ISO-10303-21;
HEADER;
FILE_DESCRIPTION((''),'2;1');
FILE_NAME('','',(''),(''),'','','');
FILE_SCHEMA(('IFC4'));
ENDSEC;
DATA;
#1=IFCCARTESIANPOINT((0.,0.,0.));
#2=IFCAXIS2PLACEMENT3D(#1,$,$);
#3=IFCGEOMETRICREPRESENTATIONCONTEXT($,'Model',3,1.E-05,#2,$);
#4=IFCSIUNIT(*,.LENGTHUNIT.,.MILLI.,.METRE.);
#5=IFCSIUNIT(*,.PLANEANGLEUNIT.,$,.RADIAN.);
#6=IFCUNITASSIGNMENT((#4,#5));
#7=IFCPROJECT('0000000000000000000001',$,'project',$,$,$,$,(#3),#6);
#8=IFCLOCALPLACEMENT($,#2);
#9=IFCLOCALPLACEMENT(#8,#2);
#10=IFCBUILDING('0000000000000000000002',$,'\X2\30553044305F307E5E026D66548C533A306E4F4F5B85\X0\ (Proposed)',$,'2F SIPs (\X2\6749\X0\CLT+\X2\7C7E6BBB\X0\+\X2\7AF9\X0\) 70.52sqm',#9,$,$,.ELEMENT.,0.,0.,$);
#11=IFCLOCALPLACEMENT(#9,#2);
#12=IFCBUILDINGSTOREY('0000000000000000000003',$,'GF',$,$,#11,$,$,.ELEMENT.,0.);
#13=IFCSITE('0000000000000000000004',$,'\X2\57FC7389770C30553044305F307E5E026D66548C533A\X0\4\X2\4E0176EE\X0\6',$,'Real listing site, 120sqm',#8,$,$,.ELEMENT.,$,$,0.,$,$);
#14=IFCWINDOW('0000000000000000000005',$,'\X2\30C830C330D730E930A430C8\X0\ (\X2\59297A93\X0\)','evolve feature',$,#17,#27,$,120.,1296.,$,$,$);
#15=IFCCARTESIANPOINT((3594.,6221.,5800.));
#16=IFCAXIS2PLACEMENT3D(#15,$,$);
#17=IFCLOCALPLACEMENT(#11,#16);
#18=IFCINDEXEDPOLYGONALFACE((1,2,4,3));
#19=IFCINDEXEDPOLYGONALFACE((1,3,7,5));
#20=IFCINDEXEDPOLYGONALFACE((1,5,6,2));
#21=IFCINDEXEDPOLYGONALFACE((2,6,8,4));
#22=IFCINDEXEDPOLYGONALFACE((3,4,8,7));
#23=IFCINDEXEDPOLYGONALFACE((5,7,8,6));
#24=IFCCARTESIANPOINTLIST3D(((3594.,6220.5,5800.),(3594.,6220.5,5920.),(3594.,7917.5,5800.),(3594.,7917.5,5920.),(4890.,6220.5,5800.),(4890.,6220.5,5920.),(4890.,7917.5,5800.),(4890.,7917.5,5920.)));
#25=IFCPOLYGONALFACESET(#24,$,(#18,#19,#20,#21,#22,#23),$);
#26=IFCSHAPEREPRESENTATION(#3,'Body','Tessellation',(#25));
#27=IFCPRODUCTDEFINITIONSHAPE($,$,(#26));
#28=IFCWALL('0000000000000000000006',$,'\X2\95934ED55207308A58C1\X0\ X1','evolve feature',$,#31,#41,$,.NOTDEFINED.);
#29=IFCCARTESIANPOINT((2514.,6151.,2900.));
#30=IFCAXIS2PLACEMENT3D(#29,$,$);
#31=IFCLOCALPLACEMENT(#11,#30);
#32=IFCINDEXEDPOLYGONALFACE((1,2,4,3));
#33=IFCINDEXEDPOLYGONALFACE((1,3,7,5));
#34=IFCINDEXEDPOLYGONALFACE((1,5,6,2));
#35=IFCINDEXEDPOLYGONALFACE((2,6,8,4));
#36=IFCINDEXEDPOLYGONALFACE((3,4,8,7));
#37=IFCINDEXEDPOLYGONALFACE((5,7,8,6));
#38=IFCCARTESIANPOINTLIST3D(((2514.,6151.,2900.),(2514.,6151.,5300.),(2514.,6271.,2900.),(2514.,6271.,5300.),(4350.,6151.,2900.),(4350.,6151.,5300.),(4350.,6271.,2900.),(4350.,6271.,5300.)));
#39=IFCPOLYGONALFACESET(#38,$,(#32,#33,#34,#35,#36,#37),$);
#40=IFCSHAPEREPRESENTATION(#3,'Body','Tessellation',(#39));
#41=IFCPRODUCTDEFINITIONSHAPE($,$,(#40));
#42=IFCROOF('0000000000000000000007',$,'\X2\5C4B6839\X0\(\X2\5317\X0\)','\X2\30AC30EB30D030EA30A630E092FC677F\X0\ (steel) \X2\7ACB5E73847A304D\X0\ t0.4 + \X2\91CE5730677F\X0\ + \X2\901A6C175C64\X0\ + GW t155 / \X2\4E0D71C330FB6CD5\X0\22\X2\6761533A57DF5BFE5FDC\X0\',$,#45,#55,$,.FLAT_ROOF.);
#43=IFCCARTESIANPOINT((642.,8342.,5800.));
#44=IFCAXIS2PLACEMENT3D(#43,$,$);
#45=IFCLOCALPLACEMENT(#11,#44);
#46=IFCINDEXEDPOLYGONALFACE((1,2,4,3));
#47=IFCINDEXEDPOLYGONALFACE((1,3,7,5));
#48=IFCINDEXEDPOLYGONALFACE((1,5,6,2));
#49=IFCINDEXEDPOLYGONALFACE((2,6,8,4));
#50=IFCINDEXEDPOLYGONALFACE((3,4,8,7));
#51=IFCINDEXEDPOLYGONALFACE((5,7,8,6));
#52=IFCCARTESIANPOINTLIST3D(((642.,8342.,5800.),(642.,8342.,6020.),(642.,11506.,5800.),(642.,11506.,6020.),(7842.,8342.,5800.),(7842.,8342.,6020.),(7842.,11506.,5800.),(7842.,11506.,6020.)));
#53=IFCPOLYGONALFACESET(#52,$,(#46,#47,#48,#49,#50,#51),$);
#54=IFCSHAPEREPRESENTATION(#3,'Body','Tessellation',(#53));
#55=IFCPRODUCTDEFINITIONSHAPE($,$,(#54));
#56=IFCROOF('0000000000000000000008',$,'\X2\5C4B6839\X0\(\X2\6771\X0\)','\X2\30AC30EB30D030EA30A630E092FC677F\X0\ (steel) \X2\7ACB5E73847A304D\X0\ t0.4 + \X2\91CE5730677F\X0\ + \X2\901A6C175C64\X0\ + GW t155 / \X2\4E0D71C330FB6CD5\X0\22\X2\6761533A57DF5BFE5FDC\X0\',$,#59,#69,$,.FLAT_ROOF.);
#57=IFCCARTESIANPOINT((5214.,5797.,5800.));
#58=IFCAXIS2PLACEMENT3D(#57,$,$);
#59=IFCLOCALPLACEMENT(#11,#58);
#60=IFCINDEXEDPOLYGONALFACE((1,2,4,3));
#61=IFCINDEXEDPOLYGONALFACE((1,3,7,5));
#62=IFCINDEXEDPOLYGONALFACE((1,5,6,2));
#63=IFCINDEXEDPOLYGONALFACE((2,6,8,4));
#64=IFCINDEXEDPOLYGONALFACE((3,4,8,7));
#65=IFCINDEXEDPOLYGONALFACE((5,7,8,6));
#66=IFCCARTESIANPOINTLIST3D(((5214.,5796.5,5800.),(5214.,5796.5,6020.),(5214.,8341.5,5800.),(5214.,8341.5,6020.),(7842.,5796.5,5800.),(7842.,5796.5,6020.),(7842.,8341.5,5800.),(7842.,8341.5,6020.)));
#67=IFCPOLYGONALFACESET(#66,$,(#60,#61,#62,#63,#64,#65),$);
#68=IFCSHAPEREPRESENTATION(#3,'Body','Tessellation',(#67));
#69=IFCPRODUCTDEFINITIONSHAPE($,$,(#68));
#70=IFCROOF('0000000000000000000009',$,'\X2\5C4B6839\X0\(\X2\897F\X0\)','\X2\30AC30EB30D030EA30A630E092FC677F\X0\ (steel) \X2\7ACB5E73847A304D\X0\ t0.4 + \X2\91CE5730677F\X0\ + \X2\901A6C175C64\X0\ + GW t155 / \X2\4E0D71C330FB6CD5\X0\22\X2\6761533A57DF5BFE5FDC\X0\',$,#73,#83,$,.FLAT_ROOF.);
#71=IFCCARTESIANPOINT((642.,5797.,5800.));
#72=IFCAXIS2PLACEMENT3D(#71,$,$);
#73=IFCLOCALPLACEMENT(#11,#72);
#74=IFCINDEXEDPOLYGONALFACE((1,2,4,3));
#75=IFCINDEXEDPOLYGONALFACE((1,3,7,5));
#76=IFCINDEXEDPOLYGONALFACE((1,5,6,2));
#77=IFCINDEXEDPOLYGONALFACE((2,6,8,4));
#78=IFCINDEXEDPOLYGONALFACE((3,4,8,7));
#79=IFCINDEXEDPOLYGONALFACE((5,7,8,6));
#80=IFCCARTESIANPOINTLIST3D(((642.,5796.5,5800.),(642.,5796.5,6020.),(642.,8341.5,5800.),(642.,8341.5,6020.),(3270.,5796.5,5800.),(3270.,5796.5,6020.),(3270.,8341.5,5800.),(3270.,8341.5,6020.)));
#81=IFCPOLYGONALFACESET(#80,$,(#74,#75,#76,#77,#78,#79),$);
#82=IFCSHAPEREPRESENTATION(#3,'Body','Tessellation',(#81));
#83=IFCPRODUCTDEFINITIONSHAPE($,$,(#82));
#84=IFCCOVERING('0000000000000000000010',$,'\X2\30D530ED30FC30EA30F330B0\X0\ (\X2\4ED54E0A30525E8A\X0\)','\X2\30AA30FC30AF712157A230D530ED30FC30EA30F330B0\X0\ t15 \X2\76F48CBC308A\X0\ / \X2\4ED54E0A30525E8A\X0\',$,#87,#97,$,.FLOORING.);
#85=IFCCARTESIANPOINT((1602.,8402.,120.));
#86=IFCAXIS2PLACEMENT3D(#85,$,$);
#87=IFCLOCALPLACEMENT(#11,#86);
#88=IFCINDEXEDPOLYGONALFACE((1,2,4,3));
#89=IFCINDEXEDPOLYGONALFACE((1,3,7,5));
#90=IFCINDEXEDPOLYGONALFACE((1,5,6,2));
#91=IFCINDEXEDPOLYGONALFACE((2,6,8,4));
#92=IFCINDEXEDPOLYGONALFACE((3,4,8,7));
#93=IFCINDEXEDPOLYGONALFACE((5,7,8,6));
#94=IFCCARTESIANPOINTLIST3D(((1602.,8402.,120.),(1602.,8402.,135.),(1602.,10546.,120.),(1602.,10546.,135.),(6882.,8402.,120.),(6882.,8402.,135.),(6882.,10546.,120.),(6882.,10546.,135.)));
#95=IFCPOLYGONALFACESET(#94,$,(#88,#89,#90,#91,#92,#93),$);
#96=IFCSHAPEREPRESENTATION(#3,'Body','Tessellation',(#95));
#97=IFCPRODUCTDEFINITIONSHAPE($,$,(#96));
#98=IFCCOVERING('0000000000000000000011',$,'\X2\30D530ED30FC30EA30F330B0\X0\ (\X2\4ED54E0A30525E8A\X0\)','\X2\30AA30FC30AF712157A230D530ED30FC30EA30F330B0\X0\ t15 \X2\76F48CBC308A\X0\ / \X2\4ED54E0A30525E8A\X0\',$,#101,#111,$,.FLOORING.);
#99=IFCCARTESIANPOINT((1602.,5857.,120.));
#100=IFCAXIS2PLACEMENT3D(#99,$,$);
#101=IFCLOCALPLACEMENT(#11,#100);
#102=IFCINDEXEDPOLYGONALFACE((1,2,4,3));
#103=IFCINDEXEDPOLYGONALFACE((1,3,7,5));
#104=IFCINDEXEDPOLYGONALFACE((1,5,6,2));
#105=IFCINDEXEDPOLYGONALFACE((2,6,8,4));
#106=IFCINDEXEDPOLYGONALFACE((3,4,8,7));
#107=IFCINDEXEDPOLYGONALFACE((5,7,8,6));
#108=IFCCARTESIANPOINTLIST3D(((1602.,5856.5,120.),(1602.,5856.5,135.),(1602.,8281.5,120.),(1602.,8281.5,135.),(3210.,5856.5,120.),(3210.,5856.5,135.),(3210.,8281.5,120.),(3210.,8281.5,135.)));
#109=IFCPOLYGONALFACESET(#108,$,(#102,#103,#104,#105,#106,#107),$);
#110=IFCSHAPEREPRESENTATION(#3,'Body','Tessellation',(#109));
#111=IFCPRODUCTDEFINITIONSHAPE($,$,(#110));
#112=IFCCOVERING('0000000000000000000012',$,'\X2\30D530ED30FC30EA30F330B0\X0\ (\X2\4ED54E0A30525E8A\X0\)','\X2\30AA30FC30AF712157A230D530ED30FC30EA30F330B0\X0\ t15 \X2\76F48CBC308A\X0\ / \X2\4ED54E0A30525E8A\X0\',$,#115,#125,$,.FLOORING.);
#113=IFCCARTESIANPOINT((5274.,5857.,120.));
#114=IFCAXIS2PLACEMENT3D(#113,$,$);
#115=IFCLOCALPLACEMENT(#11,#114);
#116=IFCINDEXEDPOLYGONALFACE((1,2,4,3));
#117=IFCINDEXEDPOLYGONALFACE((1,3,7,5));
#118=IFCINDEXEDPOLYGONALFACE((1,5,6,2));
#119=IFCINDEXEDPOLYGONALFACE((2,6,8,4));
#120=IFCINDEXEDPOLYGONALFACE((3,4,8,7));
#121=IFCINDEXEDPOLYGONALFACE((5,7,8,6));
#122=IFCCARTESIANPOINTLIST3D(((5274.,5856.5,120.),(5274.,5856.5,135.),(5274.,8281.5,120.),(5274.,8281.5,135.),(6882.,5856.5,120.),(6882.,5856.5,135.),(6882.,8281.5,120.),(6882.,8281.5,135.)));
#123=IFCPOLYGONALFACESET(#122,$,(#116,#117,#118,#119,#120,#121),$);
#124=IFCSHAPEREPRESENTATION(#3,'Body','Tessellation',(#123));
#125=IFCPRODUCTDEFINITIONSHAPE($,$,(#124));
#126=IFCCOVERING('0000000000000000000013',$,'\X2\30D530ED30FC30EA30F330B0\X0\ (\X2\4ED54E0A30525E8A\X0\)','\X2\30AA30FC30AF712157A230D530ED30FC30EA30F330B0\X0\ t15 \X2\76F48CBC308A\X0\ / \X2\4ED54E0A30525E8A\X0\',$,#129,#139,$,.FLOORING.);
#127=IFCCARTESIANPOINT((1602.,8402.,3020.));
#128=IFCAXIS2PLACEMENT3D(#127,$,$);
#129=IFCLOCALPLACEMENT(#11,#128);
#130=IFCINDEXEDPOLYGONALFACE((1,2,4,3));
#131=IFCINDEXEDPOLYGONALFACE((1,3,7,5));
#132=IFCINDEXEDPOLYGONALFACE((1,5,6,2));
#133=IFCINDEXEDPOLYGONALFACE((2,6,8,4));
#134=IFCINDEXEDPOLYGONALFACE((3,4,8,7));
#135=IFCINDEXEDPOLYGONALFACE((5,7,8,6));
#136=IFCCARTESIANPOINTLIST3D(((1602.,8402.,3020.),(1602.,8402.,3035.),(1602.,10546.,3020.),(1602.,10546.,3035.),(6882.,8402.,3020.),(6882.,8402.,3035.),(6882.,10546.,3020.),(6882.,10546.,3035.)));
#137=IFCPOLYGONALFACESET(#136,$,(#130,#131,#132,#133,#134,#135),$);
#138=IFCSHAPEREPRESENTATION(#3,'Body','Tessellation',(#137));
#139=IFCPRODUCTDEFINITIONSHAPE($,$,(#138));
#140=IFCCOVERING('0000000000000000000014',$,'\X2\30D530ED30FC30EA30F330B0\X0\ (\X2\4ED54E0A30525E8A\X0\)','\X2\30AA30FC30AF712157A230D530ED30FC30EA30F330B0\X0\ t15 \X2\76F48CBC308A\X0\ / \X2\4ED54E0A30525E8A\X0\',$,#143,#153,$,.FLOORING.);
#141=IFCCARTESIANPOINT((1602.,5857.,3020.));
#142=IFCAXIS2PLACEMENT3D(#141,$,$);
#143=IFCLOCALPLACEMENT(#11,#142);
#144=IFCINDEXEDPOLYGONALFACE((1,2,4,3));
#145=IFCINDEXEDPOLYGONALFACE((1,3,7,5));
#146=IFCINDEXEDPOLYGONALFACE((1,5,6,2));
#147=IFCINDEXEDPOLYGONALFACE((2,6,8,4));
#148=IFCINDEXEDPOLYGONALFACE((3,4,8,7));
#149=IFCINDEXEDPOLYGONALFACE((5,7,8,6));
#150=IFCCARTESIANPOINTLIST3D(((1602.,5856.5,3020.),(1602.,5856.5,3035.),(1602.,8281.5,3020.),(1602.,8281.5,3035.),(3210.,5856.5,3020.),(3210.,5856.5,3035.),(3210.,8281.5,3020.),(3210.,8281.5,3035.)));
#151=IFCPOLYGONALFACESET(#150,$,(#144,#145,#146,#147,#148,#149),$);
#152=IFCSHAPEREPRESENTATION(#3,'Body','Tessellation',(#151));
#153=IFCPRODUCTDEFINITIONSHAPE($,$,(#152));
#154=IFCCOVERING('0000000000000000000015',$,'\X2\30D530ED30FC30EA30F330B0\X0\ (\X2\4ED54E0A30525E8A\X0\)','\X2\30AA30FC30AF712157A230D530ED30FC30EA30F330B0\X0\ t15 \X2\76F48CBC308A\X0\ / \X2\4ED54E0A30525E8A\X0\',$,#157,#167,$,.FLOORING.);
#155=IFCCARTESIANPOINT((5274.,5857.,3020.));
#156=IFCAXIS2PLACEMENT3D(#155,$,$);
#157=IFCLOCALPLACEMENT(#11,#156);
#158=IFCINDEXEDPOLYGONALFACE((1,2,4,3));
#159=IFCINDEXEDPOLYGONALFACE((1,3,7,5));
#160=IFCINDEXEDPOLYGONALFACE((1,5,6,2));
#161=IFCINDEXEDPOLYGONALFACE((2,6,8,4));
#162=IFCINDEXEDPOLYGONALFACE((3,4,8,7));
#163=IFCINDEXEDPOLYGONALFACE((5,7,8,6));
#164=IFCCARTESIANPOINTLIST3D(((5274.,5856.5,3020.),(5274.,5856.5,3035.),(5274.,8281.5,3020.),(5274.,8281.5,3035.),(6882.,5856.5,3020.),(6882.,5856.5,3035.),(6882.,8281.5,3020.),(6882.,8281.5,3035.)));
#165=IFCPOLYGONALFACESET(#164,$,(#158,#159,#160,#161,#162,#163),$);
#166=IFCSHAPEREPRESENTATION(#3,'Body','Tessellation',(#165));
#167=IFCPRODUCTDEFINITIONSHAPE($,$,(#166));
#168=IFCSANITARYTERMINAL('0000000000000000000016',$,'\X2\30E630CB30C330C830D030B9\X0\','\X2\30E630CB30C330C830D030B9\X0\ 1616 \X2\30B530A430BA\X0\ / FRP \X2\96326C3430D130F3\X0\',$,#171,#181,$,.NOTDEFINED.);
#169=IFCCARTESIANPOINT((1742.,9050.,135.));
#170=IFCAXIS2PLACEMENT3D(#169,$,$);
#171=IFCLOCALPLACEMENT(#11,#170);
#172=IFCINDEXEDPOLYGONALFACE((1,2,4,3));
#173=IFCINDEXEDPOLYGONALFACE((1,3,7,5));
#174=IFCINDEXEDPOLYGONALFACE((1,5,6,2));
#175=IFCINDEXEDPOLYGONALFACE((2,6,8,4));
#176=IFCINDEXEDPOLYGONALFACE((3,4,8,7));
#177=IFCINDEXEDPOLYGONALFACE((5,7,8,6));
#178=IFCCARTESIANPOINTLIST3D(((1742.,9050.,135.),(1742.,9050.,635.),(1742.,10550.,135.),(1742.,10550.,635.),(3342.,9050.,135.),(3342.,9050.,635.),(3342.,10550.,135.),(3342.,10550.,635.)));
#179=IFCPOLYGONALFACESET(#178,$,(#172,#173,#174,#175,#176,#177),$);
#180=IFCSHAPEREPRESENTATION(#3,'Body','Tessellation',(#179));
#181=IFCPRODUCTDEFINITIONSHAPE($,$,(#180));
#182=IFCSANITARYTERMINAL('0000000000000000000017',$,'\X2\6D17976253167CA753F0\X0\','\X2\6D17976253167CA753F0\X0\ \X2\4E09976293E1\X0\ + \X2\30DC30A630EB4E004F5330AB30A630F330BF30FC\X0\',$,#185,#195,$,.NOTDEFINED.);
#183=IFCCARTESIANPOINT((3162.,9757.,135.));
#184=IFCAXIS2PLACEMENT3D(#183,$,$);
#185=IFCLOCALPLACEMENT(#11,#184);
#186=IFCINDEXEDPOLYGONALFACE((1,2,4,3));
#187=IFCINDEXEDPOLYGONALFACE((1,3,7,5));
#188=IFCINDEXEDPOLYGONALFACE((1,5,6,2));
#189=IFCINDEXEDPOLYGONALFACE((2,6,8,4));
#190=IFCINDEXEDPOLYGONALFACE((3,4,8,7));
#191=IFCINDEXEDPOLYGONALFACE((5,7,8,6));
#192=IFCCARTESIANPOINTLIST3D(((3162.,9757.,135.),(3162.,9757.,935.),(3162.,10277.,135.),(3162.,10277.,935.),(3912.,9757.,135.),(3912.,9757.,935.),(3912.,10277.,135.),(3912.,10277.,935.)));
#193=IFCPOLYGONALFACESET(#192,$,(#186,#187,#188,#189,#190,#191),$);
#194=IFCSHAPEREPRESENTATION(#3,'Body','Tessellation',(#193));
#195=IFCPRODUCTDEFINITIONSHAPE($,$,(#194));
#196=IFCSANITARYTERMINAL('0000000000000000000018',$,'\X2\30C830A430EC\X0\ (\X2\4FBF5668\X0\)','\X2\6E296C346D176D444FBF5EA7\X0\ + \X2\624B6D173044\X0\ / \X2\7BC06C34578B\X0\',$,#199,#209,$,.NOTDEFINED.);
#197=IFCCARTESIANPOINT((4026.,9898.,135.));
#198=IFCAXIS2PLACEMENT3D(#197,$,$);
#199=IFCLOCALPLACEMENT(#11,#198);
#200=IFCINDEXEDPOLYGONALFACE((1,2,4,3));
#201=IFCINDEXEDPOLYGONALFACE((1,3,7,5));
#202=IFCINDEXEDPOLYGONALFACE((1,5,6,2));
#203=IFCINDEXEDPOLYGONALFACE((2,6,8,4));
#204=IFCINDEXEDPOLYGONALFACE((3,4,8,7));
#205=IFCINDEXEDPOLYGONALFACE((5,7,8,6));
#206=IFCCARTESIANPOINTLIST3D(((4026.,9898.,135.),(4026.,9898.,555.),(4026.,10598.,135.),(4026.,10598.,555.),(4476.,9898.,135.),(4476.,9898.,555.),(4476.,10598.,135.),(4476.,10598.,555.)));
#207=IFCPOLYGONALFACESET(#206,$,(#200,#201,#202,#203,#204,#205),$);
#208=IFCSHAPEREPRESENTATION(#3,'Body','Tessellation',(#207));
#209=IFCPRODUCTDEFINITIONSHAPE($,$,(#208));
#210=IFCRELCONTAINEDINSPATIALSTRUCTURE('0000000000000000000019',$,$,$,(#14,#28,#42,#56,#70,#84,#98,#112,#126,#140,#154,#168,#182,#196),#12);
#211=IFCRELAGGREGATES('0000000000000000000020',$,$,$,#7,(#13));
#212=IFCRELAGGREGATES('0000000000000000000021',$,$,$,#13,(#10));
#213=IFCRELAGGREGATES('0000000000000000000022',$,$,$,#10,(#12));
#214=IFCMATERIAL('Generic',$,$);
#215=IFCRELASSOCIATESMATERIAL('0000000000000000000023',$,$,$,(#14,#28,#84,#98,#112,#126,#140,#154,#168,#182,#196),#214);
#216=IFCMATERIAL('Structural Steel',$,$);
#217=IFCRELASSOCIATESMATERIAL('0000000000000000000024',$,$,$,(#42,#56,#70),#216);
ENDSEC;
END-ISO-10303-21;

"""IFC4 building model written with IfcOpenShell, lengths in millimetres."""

from ifc_helpers import new_model, si_unit, frame, frame_2d, origin, place, context, project, spatial, rectangle, extrude, material, element, save


model = new_model("IFC4")

# Units and contexts
model_context = context("Model", 3, precision=1e-05, world=origin())
ifc_project = project(units=[si_unit("LENGTHUNIT", "METRE", prefix="MILLI"), si_unit("PLANEANGLEUNIT", "RADIAN")], contexts=[model_context])

# Site, building, storey
site_placement = place(None, origin())
site = spatial("IfcSite", under=ifc_project, at=site_placement, Name="埼玉県さいたま市浦和区4丁目6", ObjectType="Real listing site, 120sqm", CompositionType="ELEMENT", RefElevation=0.0)
building_placement = place(site_placement, origin())
building = spatial("IfcBuilding", under=site, at=building_placement, Name="さいたま市浦和区の住宅 (Proposed)", ObjectType="2F SIPs (杉CLT+籾殻+竹) 70.52sqm", CompositionType="ELEMENT", ElevationOfRefHeight=0.0, ElevationOfTerrain=0.0)
storey_placement = place(building_placement, origin())
storey = spatial("IfcBuildingStorey", under=building, at=storey_placement, Name="GF", CompositionType="ELEMENT", Elevation=0.0)

# Window
ifc_material_1 = material(Name="Generic")
window_1_placement = place(storey_placement, frame((3594.0, 6221.0, 5800.0)))
element("IfcWindow", 1, at=window_1_placement, inside=storey, material=ifc_material_1, Name="トップライト (天窓)", Description="evolve feature", OverallHeight=120.0, OverallWidth=1296.0, context=model_context, shape_type="SweptSolid", body=[
    extrude(rectangle(XDim=1296.0, YDim=1697.0, at=frame_2d((648.0, 848.0))), frame((3594.0, 6221.0, 5800.0)), (0.0, 0.0, 1.0), 120.0),
])

# Wall
wall_1_placement = place(storey_placement, frame((2514.0, 6151.0, 2900.0)))
element("IfcWall", 2, at=wall_1_placement, inside=storey, material=ifc_material_1, Name="間仕切り壁 X1", Description="evolve feature", PredefinedType="NOTDEFINED", context=model_context, shape_type="SweptSolid", body=[
    extrude(rectangle(XDim=1836.0, YDim=120.0, at=frame_2d((918.0, 60.0))), frame((2514.0, 6151.0, 2900.0)), (0.0, 0.0, 1.0), 2400.0),
])

# Roofs
ifc_material_2 = material(Name="Structural Steel")
roof_1_placement = place(storey_placement, frame((642.0, 8342.0, 5800.0)))
element("IfcRoof", 3, at=roof_1_placement, inside=storey, material=ifc_material_2, Name="屋根(北)", Description="ガルバリウム鋼板 (steel) 立平葺き t0.4 + 野地板 + 通気層 + GW t155 / 不燃・法22条区域対応", PredefinedType="FLAT_ROOF", context=model_context, shape_type="SweptSolid", body=[
    extrude(rectangle(XDim=7200.0, YDim=3164.0, at=frame_2d((3600.0, 1582.0))), frame((642.0, 8342.0, 5800.0)), (0.0, 0.0, 1.0), 220.0),
])
roof_2_placement = place(storey_placement, frame((5214.0, 5797.0, 5800.0)))
element("IfcRoof", 4, at=roof_2_placement, inside=storey, material=ifc_material_2, Name="屋根(東)", Description="ガルバリウム鋼板 (steel) 立平葺き t0.4 + 野地板 + 通気層 + GW t155 / 不燃・法22条区域対応", PredefinedType="FLAT_ROOF", context=model_context, shape_type="SweptSolid", body=[
    extrude(rectangle(XDim=2628.0, YDim=2545.0, at=frame_2d((1314.0, 1272.0))), frame((5214.0, 5797.0, 5800.0)), (0.0, 0.0, 1.0), 220.0),
])
roof_3_placement = place(storey_placement, frame((642.0, 5797.0, 5800.0)))
element("IfcRoof", 5, at=roof_3_placement, inside=storey, material=ifc_material_2, Name="屋根(西)", Description="ガルバリウム鋼板 (steel) 立平葺き t0.4 + 野地板 + 通気層 + GW t155 / 不燃・法22条区域対応", PredefinedType="FLAT_ROOF", context=model_context, shape_type="SweptSolid", body=[
    extrude(rectangle(XDim=2628.0, YDim=2545.0, at=frame_2d((1314.0, 1272.0))), frame((642.0, 5797.0, 5800.0)), (0.0, 0.0, 1.0), 220.0),
])

# Coverings
covering_1_placement = place(storey_placement, frame((1602.0, 8402.0, 120.0)))
element("IfcCovering", 6, at=covering_1_placement, inside=storey, material=ifc_material_1, Name="フローリング (仕上げ床)", Description="オーク無垢フローリング t15 直貼り / 仕上げ床", PredefinedType="FLOORING", context=model_context, shape_type="SweptSolid", body=[
    extrude(rectangle(XDim=5280.0, YDim=2144.0, at=frame_2d((2640.0, 1072.0))), frame((1602.0, 8402.0, 120.0)), (0.0, 0.0, 1.0), 15.0),
])
covering_2_placement = place(storey_placement, frame((1602.0, 5857.0, 120.0)))
element("IfcCovering", 7, at=covering_2_placement, inside=storey, material=ifc_material_1, Name="フローリング (仕上げ床)", Description="オーク無垢フローリング t15 直貼り / 仕上げ床", PredefinedType="FLOORING", context=model_context, shape_type="SweptSolid", body=[
    extrude(rectangle(XDim=1608.0, YDim=2425.0, at=frame_2d((804.0, 1212.0))), frame((1602.0, 5857.0, 120.0)), (0.0, 0.0, 1.0), 15.0),
])
covering_3_placement = place(storey_placement, frame((5274.0, 5857.0, 120.0)))
element("IfcCovering", 8, at=covering_3_placement, inside=storey, material=ifc_material_1, Name="フローリング (仕上げ床)", Description="オーク無垢フローリング t15 直貼り / 仕上げ床", PredefinedType="FLOORING", context=model_context, shape_type="SweptSolid", body=[
    extrude(rectangle(XDim=1608.0, YDim=2425.0, at=frame_2d((804.0, 1212.0))), frame((5274.0, 5857.0, 120.0)), (0.0, 0.0, 1.0), 15.0),
])
covering_4_placement = place(storey_placement, frame((1602.0, 8402.0, 3020.0)))
element("IfcCovering", 9, at=covering_4_placement, inside=storey, material=ifc_material_1, Name="フローリング (仕上げ床)", Description="オーク無垢フローリング t15 直貼り / 仕上げ床", PredefinedType="FLOORING", context=model_context, shape_type="SweptSolid", body=[
    extrude(rectangle(XDim=5280.0, YDim=2144.0, at=frame_2d((2640.0, 1072.0))), frame((1602.0, 8402.0, 3020.0)), (0.0, 0.0, 1.0), 15.0),
])
covering_5_placement = place(storey_placement, frame((1602.0, 5857.0, 3020.0)))
element("IfcCovering", 10, at=covering_5_placement, inside=storey, material=ifc_material_1, Name="フローリング (仕上げ床)", Description="オーク無垢フローリング t15 直貼り / 仕上げ床", PredefinedType="FLOORING", context=model_context, shape_type="SweptSolid", body=[
    extrude(rectangle(XDim=1608.0, YDim=2425.0, at=frame_2d((804.0, 1212.0))), frame((1602.0, 5857.0, 3020.0)), (0.0, 0.0, 1.0), 15.0),
])
covering_6_placement = place(storey_placement, frame((5274.0, 5857.0, 3020.0)))
element("IfcCovering", 11, at=covering_6_placement, inside=storey, material=ifc_material_1, Name="フローリング (仕上げ床)", Description="オーク無垢フローリング t15 直貼り / 仕上げ床", PredefinedType="FLOORING", context=model_context, shape_type="SweptSolid", body=[
    extrude(rectangle(XDim=1608.0, YDim=2425.0, at=frame_2d((804.0, 1212.0))), frame((5274.0, 5857.0, 3020.0)), (0.0, 0.0, 1.0), 15.0),
])

# Sanitary terminals
sanitary_terminal_1_placement = place(storey_placement, frame((1742.0, 9050.0, 135.0)))
element("IfcSanitaryTerminal", 12, at=sanitary_terminal_1_placement, inside=storey, material=ifc_material_1, Name="ユニットバス", Description="ユニットバス 1616 サイズ / FRP 防水パン", PredefinedType="NOTDEFINED", context=model_context, shape_type="SweptSolid", body=[
    extrude(rectangle(XDim=1600.0, YDim=1500.0, at=frame_2d((800.0, 750.0))), frame((1742.0, 9050.0, 135.0)), (0.0, 0.0, 1.0), 500.0),
])
sanitary_terminal_2_placement = place(storey_placement, frame((3162.0, 9757.0, 135.0)))
element("IfcSanitaryTerminal", 13, at=sanitary_terminal_2_placement, inside=storey, material=ifc_material_1, Name="洗面化粧台", Description="洗面化粧台 三面鏡 + ボウル一体カウンター", PredefinedType="NOTDEFINED", context=model_context, shape_type="SweptSolid", body=[
    extrude(rectangle(XDim=750.0, YDim=520.0, at=frame_2d((375.0, 260.0))), frame((3162.0, 9757.0, 135.0)), (0.0, 0.0, 1.0), 800.0),
])
sanitary_terminal_3_placement = place(storey_placement, frame((4026.0, 9898.0, 135.0)))
element("IfcSanitaryTerminal", 14, at=sanitary_terminal_3_placement, inside=storey, material=ifc_material_1, Name="トイレ (便器)", Description="温水洗浄便座 + 手洗い / 節水型", PredefinedType="NOTDEFINED", context=model_context, shape_type="SweptSolid", body=[
    extrude(rectangle(XDim=450.0, YDim=700.0, at=frame_2d((225.0, 350.0))), frame((4026.0, 9898.0, 135.0)), (0.0, 0.0, 1.0), 420.0),
])

save(model, "model.ifc")
